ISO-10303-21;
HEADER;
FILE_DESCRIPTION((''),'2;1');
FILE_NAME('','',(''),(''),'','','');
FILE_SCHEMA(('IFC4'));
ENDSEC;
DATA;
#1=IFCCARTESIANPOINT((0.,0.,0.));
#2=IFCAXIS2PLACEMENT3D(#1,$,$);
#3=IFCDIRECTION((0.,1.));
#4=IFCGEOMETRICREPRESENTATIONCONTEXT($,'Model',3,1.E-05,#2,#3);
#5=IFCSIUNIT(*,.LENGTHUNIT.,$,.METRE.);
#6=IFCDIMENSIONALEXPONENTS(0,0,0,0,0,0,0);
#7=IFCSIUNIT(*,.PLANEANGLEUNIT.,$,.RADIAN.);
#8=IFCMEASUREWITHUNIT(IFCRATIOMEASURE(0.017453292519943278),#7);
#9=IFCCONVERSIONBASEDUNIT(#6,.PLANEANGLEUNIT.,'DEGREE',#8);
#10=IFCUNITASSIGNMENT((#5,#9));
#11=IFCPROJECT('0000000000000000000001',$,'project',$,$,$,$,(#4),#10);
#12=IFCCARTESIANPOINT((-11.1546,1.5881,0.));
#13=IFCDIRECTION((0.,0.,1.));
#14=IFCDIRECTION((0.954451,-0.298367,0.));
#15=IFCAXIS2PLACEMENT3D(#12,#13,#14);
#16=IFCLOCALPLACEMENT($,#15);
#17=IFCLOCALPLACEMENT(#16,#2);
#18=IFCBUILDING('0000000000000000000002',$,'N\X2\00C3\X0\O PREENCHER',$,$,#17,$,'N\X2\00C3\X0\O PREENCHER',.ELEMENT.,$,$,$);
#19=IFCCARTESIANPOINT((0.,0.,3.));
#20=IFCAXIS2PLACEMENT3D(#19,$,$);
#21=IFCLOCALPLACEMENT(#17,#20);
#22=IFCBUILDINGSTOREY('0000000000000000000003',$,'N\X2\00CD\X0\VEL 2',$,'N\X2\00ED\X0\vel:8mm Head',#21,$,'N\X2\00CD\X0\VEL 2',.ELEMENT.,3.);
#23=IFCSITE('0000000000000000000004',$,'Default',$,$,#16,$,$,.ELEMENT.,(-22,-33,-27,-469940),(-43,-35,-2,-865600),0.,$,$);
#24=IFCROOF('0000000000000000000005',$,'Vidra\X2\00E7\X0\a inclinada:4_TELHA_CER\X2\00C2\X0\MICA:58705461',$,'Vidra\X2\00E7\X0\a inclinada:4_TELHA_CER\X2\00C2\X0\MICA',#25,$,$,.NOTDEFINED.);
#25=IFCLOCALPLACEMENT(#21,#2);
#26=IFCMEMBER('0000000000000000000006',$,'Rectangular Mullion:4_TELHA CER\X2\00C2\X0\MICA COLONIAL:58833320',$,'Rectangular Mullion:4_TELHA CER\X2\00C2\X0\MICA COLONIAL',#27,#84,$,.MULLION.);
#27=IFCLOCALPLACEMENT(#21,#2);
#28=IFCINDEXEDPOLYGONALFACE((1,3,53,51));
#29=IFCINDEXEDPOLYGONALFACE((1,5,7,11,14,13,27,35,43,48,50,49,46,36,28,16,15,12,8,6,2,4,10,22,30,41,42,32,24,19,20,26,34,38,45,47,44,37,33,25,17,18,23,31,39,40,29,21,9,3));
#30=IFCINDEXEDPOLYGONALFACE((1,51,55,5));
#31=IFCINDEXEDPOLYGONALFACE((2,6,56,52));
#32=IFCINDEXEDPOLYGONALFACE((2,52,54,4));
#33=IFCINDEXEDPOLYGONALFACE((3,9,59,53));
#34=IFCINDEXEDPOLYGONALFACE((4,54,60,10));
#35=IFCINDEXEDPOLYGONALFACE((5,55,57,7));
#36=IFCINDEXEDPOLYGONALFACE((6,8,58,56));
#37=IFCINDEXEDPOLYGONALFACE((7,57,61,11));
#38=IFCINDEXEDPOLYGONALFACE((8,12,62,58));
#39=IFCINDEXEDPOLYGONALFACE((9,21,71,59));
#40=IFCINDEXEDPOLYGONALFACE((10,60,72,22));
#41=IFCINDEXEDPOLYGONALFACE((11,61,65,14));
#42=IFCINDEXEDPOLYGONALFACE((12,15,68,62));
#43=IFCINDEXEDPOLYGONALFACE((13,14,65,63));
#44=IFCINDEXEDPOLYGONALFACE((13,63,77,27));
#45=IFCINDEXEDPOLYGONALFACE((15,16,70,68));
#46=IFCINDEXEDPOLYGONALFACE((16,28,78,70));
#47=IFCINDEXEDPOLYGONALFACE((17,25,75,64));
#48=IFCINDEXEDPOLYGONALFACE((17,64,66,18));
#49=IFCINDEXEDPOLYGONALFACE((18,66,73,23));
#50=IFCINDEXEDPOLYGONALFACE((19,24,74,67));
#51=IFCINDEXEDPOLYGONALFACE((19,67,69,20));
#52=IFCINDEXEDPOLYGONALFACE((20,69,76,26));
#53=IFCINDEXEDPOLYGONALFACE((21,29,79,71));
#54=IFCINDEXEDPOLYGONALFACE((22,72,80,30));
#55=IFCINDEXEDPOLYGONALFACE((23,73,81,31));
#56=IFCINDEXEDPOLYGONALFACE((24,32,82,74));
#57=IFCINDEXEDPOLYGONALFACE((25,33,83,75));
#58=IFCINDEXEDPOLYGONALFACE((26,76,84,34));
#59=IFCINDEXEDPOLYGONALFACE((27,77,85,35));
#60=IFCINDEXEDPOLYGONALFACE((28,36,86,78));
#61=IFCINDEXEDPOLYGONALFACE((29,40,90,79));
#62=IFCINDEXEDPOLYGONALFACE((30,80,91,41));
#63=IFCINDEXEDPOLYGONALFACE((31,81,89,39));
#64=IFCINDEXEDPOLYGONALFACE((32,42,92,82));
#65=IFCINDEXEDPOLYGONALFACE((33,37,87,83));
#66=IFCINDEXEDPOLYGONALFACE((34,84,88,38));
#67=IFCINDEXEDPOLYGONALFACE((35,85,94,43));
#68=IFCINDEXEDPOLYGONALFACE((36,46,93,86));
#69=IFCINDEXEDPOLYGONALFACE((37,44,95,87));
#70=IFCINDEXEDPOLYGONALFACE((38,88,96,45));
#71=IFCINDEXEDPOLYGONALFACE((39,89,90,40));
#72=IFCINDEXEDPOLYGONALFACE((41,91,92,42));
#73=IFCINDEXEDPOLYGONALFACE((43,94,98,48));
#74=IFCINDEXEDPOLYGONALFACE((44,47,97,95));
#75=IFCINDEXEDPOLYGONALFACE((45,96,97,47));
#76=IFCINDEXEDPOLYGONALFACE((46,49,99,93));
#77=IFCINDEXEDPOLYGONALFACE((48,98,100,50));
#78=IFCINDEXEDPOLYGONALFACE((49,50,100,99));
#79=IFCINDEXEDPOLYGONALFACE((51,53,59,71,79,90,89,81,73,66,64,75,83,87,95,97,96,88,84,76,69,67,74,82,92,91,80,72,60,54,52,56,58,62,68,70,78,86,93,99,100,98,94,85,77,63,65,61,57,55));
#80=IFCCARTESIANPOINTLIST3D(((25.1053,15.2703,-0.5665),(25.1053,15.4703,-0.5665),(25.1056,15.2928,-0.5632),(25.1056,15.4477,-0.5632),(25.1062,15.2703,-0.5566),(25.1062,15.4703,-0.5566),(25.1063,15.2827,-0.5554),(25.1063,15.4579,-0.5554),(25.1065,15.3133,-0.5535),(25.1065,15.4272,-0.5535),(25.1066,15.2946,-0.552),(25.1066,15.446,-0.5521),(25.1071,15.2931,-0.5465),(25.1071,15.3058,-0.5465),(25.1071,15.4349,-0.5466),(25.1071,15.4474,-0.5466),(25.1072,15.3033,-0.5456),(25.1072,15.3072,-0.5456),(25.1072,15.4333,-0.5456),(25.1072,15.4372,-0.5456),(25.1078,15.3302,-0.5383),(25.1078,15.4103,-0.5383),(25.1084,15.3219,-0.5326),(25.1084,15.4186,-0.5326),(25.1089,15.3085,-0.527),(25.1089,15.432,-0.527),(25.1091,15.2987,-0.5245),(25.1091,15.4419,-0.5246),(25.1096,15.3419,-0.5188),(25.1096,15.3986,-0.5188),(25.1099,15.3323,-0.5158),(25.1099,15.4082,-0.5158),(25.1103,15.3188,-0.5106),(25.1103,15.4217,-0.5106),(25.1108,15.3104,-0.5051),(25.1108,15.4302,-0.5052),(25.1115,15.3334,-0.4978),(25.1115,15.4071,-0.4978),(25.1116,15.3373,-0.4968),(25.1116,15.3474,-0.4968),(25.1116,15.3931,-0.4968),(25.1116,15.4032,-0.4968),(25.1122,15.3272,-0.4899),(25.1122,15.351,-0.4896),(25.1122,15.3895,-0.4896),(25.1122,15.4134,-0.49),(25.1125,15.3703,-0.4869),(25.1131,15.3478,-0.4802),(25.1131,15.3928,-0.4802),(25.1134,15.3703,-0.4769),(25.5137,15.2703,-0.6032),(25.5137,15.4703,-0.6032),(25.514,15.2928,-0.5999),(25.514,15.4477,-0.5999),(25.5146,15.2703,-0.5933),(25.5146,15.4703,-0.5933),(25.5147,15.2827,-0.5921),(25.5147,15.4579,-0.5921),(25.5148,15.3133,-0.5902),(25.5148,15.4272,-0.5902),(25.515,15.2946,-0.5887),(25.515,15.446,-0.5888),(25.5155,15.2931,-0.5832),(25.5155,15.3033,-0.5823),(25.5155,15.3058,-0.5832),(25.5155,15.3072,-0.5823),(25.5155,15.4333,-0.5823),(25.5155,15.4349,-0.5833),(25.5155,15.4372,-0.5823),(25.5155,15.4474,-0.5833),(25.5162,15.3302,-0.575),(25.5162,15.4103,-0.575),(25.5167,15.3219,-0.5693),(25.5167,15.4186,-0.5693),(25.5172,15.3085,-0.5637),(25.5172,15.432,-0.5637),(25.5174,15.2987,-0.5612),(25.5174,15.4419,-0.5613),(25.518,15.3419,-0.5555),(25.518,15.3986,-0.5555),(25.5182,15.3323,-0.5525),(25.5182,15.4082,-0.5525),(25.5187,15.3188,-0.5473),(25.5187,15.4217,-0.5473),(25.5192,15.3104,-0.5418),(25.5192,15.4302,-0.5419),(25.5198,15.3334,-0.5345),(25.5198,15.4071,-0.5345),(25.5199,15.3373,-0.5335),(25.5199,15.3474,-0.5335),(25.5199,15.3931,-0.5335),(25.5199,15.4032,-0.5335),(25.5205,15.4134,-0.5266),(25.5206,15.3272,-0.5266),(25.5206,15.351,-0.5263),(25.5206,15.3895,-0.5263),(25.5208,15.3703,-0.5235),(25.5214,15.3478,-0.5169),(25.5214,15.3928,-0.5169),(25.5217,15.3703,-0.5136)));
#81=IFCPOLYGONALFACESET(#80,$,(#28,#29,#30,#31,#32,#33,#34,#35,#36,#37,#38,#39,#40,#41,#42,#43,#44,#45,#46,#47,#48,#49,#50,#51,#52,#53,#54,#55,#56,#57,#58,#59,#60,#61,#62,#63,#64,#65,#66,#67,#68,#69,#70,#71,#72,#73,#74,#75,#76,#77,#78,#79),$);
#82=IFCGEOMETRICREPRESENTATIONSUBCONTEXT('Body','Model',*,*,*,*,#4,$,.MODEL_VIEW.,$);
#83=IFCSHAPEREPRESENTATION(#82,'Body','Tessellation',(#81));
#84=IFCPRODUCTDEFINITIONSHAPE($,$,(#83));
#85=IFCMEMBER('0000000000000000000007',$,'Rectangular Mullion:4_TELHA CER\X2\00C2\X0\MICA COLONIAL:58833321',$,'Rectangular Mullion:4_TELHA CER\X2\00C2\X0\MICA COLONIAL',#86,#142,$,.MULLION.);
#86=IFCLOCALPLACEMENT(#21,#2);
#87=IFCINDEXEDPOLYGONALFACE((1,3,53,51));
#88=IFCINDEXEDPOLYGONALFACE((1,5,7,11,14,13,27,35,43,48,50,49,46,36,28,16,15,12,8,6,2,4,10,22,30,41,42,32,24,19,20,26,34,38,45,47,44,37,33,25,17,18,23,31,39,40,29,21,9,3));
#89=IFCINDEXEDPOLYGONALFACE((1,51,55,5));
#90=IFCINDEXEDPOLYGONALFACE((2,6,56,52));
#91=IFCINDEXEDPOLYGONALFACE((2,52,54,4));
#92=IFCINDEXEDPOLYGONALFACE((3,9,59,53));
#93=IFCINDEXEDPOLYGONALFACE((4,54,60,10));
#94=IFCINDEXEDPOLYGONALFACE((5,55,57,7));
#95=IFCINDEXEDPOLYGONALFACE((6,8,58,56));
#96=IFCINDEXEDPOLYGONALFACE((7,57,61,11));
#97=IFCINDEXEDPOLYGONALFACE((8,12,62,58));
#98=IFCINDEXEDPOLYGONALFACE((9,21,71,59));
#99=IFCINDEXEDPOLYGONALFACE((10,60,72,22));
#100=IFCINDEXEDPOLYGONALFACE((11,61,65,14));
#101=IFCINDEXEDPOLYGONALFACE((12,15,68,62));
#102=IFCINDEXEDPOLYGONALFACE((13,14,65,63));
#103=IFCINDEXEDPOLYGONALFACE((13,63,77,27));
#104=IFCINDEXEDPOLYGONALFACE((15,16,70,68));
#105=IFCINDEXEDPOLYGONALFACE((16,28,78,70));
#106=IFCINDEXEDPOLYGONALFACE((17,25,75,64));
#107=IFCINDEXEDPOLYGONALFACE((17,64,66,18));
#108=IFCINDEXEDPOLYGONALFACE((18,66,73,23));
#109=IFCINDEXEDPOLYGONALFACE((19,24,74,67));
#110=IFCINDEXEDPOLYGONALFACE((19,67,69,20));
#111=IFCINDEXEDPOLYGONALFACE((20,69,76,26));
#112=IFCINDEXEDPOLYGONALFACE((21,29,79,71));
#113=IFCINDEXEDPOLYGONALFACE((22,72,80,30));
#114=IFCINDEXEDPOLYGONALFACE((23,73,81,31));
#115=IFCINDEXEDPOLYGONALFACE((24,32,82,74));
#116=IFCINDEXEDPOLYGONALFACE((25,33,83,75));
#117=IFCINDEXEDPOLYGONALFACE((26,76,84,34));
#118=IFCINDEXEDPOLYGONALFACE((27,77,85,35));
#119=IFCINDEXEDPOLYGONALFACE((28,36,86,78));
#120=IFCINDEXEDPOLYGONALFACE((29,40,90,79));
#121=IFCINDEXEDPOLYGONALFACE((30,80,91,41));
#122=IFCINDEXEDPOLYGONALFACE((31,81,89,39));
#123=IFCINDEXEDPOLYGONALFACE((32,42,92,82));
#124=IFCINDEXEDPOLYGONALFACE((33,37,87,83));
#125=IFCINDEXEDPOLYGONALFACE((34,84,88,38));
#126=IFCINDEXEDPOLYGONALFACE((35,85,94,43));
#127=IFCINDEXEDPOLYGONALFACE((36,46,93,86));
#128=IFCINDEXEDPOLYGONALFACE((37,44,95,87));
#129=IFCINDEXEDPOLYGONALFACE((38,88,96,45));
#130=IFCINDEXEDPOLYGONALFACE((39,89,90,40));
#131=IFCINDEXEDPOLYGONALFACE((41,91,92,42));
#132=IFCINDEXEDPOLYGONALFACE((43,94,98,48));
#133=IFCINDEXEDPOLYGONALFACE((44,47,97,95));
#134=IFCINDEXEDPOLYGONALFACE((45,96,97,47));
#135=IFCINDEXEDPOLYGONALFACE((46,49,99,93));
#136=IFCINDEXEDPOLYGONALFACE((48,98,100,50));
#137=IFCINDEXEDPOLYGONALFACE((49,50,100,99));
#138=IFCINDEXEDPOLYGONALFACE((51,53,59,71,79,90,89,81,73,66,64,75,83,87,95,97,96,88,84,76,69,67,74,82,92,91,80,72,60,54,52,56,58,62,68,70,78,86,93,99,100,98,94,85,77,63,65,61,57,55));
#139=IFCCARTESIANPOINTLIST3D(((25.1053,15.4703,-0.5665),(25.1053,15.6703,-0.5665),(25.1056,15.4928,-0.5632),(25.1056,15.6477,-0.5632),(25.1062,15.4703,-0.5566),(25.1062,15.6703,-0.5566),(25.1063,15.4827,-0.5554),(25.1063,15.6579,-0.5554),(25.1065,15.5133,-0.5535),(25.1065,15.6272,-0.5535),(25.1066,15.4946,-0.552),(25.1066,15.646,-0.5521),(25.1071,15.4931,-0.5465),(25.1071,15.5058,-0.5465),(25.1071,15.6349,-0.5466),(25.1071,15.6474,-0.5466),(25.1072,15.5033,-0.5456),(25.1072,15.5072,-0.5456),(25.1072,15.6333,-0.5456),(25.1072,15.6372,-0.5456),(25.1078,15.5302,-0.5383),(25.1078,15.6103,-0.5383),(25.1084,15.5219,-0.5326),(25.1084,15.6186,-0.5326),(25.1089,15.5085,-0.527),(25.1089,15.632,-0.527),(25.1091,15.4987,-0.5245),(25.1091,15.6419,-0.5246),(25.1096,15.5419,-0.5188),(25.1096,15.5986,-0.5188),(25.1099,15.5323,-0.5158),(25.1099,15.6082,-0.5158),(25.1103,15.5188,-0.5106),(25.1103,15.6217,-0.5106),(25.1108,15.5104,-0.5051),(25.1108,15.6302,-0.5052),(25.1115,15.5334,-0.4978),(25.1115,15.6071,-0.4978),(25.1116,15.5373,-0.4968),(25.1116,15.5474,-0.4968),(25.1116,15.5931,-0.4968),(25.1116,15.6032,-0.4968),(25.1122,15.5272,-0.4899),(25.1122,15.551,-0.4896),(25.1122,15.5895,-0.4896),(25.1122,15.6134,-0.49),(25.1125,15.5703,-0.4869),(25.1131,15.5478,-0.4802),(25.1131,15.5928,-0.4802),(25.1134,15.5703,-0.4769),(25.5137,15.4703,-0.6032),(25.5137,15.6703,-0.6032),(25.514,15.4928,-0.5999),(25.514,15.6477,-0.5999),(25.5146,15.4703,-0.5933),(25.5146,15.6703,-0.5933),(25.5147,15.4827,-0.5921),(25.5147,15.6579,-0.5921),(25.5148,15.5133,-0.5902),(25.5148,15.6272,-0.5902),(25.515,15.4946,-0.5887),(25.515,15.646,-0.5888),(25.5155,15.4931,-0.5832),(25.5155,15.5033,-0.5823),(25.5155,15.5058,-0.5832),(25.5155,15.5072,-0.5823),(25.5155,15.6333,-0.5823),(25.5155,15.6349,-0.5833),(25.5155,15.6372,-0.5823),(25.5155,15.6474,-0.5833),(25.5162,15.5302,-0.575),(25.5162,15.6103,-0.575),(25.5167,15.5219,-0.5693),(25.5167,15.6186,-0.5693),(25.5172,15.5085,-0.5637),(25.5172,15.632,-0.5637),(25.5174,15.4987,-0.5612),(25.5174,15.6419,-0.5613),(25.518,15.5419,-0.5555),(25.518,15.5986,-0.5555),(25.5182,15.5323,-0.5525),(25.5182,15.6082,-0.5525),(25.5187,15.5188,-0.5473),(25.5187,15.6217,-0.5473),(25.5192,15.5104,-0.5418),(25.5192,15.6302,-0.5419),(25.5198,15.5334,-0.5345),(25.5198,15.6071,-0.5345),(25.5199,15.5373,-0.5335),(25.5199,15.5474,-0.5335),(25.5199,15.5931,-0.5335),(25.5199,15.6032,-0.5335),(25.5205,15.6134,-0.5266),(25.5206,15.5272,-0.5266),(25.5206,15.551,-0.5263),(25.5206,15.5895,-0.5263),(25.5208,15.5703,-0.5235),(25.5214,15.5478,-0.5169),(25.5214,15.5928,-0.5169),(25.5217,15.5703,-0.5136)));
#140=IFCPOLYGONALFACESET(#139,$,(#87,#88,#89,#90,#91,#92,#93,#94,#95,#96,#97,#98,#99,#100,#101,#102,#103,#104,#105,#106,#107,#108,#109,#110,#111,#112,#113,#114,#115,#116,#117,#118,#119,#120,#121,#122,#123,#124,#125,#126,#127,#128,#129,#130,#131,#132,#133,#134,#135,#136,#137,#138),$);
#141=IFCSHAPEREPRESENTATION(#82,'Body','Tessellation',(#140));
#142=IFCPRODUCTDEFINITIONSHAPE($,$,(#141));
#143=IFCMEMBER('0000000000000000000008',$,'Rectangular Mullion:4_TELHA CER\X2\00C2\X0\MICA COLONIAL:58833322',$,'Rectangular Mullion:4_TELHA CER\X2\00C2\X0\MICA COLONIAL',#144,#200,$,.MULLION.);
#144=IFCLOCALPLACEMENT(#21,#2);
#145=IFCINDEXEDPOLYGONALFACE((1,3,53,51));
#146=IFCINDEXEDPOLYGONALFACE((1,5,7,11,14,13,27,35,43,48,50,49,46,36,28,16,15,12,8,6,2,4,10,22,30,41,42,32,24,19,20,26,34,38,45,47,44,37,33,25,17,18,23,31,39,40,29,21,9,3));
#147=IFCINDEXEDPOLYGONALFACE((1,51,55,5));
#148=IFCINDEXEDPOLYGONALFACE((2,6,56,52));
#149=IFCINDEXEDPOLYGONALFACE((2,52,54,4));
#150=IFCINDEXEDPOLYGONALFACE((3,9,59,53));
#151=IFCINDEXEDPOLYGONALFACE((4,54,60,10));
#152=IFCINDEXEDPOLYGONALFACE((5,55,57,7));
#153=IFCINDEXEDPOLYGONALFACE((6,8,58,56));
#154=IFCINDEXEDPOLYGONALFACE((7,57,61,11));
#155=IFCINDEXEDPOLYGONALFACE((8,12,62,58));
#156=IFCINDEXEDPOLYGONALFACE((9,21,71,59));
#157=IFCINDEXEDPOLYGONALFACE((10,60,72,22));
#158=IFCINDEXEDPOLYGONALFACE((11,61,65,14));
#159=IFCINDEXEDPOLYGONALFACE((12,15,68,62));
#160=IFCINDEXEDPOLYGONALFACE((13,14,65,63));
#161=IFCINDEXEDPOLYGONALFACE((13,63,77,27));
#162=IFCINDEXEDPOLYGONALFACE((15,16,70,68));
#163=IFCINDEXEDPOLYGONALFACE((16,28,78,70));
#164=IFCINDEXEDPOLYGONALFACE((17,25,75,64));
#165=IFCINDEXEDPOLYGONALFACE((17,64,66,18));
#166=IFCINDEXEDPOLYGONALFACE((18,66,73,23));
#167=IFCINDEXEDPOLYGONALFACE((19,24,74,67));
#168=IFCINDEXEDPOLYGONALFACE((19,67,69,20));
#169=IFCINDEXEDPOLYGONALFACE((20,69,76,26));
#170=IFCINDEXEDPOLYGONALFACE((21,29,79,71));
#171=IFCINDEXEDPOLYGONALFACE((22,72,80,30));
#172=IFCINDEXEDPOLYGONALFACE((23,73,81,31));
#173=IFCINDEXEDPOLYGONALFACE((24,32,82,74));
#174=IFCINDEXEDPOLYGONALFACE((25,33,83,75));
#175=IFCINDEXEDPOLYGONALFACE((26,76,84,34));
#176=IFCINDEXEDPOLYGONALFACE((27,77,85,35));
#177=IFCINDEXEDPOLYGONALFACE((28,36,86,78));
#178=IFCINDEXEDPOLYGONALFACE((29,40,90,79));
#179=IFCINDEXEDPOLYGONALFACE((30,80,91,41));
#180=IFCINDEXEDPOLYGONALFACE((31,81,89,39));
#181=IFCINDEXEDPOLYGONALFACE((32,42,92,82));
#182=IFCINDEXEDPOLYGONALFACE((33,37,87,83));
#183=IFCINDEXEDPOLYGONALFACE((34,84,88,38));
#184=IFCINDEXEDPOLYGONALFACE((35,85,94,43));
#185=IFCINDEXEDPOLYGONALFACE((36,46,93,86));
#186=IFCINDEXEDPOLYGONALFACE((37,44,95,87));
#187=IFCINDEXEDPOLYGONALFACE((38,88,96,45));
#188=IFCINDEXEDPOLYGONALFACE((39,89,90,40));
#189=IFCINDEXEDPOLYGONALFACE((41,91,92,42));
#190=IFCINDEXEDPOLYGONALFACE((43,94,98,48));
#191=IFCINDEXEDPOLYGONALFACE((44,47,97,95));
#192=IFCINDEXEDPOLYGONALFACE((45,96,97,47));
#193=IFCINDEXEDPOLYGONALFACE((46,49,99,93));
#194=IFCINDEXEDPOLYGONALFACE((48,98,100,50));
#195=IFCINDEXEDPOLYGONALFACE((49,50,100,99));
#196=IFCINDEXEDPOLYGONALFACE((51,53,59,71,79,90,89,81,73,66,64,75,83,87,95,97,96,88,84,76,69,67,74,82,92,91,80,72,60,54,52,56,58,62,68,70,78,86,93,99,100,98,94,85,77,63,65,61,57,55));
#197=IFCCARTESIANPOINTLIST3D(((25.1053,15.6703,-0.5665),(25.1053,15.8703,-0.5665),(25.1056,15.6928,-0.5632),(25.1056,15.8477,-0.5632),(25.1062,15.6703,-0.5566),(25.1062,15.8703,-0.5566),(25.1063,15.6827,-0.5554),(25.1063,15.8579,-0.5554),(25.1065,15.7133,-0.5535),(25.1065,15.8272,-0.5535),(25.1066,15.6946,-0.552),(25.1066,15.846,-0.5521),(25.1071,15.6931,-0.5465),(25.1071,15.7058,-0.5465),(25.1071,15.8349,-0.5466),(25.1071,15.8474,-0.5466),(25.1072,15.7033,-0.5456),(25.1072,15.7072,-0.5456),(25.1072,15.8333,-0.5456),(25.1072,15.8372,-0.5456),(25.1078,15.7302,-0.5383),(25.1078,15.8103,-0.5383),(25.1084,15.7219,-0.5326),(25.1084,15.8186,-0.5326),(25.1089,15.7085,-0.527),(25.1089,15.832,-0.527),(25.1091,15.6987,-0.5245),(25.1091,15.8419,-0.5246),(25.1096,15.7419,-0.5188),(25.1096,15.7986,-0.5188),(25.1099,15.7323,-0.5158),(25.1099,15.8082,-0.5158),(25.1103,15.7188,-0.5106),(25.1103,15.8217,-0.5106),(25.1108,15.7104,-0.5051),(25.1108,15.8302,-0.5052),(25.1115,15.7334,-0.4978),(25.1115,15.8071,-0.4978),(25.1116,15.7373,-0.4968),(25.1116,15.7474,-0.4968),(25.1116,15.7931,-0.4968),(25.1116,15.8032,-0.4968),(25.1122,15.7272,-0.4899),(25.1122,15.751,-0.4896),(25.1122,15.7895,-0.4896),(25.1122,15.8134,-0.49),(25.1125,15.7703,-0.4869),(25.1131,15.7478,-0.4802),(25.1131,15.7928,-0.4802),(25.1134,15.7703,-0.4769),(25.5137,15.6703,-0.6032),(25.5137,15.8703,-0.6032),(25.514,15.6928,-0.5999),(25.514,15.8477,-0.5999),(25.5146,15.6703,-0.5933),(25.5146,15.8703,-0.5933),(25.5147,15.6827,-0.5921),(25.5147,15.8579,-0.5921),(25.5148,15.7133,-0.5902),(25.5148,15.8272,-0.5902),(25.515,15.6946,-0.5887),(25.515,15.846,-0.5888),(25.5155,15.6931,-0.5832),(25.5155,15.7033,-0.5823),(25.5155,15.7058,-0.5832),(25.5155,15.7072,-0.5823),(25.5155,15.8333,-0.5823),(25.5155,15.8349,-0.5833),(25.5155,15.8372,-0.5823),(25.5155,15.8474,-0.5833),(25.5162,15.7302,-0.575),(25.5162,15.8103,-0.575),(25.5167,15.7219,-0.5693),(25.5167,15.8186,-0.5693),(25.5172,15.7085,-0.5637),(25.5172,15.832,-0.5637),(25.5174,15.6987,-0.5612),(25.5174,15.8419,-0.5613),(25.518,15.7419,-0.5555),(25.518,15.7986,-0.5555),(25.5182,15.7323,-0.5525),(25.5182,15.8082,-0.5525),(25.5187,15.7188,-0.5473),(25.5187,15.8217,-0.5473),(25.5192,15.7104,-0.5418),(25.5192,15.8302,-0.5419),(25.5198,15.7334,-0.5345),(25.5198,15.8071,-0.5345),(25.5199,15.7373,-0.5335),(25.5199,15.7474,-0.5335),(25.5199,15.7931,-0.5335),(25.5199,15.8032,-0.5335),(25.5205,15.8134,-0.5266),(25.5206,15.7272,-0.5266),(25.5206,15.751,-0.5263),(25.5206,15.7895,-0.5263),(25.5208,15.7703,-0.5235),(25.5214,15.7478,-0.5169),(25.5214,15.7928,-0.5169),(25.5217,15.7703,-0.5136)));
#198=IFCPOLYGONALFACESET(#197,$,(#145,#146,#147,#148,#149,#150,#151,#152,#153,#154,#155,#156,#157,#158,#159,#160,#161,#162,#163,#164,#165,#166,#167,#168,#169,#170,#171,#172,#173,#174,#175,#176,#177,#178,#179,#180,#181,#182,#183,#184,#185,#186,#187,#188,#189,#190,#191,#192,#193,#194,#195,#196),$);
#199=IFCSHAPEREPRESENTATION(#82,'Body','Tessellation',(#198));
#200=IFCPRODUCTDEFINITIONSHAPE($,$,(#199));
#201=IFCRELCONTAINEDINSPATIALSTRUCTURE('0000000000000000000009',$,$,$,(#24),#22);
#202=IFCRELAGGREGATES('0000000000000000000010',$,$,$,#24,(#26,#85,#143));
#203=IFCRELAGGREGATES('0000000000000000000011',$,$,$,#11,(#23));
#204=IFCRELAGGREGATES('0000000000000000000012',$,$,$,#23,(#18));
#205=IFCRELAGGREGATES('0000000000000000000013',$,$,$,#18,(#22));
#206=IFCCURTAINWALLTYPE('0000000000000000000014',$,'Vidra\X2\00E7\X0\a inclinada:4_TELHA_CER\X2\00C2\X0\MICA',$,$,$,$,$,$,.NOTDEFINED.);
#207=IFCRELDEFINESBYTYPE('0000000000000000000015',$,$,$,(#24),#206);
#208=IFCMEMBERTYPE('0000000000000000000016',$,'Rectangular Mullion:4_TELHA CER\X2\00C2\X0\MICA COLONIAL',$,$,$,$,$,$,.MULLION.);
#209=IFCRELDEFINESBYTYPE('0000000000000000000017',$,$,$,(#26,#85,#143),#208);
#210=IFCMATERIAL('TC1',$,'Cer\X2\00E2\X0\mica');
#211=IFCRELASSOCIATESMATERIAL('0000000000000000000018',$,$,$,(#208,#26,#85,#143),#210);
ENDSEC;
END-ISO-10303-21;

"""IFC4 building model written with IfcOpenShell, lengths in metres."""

from ifc_helpers import new_model, entity, si_unit, converted_unit, direction, frame, origin, place, context, subcontext, project, spatial, line, arc, indexed_curve, outline, extrude, source, transform, mapped, material, type_object, type_shapes, element, aggregate, save


model = new_model("IFC4")

# Units and contexts
model_context = context("Model", 3, precision=1e-05, world=origin(), true_north=direction((0.0, 1.0)))
body_context = subcontext(model_context, "Body", "Model", "MODEL_VIEW")
ifc_project = project(units=[si_unit("LENGTHUNIT", "METRE"), converted_unit("PLANEANGLEUNIT", "DEGREE", entity("IfcRatioMeasure", 0.017453292519943278), si_unit("PLANEANGLEUNIT", "RADIAN"), dimensions=[0, 0, 0, 0, 0, 0, 0])], contexts=[model_context])

# Site, building, storey
site_placement = place(None, frame((-11.1546, 1.5881, 0.0), z_axis=(0.0, 0.0, 1.0), x_axis=(0.954451, -0.298367, 0.0)))
site = spatial("IfcSite", under=ifc_project, at=site_placement, Name="Default", CompositionType="ELEMENT", RefLatitude=(-22, -33, -27, -469940), RefLongitude=(-43, -35, -2, -865600), RefElevation=0.0)
building_placement = place(site_placement, origin())
building = spatial("IfcBuilding", under=site, at=building_placement, Name="NÃO PREENCHER", LongName="NÃO PREENCHER", CompositionType="ELEMENT")
storey_placement = place(building_placement, frame((0.0, 0.0, 3.0)))
storey = spatial("IfcBuildingStorey", under=building, at=storey_placement, Name="NÍVEL 2", ObjectType="Nível:8mm Head", LongName="NÍVEL 2", CompositionType="ELEMENT", Elevation=3.0)

# Roof, members
curtain_wall_type = type_object("IfcCurtainWallType", Name="Vidraça inclinada:4_TELHA_CERÂMICA", PredefinedType="NOTDEFINED")
roof_placement = place(storey_placement, frame((0.0, 0.0, -3.0)))
roof = element("IfcRoof", 1, at=roof_placement, inside=storey, type_object=curtain_wall_type, Name="Vidraça inclinada:4_TELHA_CERÂMICA:58705461", ObjectType="Vidraça inclinada:4_TELHA_CERÂMICA", PredefinedType="NOTDEFINED")
ifc_material = material(Name="TC1", Category="Cerâmica")
member_type = type_object("IfcMemberType", Name="Rectangular Mullion:4_TELHA CERÂMICA COLONIAL", PredefinedType="MULLION", material=ifc_material)
shared_shape = source(origin(), body_context, "Body", "SweptSolid", [
    extrude(outline(indexed_curve([(-0.029, -0.1), (-0.019, -0.1), (-0.0164, -0.0815), (-0.0089, -0.0645), (-0.0089, -0.0771), (0.061, 0.0), (-0.009, 0.0771), (-0.009, 0.0646), (-0.0165, 0.0816), (-0.019, 0.1), (-0.029, 0.1), (-0.0089, 0.0479), (0.041, 0.0229), (0.041, 0.0329), (0.0131, 0.0425), (-0.008, 0.0631), (-0.008, 0.067), (0.051, 0.0), (-0.008, -0.067), (-0.008, -0.0631), (0.0131, -0.0425), (0.041, -0.0329), (0.041, -0.0229), (-0.0089, -0.0479)], segments=[line(1, 2), arc(2, 3, 4), line(4, 5), arc(5, 6, 7), line(7, 8), arc(8, 9, 10), line(10, 11), arc(11, 12, 13), line(13, 14), arc(14, 15, 16), line(16, 17), arc(17, 18, 19), line(19, 20), arc(20, 21, 22), line(22, 23), arc(23, 24, 1)], self_intersect=False)), frame((0.0, -0.029, -0.41), z_axis=(0.0, 0.0, 1.0), x_axis=(0.0, -1.0, 0.0)), (0.0, 0.0, 1.0), 0.41),
])
type_shapes(member_type, [shared_shape])
member_1_placement = place(roof_placement, frame((25.1053, 15.3703, 2.4335), z_axis=(-0.99599, 0.0, 0.089469), x_axis=(0.0, 1.0, 0.0)))
member_1 = element("IfcMember", 2, at=member_1_placement, type_object=member_type, material=ifc_material, Name="Rectangular Mullion:4_TELHA CERÂMICA COLONIAL:58833320", ObjectType="Rectangular Mullion:4_TELHA CERÂMICA COLONIAL", PredefinedType="MULLION", context=body_context, shape_type="MappedRepresentation", body=[
    mapped(shared_shape, transform((0.0, 0.0, 0.0), scale=1.0)),
])
member_2_placement = place(roof_placement, frame((25.1053, 15.5703, 2.4335), z_axis=(-0.99599, 0.0, 0.089469), x_axis=(0.0, 1.0, 0.0)))
member_2 = element("IfcMember", 3, at=member_2_placement, type_object=member_type, material=ifc_material, Name="Rectangular Mullion:4_TELHA CERÂMICA COLONIAL:58833321", ObjectType="Rectangular Mullion:4_TELHA CERÂMICA COLONIAL", PredefinedType="MULLION", context=body_context, shape_type="MappedRepresentation", body=[
    mapped(shared_shape, transform((0.0, 0.0, 0.0), scale=1.0)),
])
member_3_placement = place(roof_placement, frame((25.1053, 15.7703, 2.4335), z_axis=(-0.99599, 0.0, 0.089469), x_axis=(0.0, 1.0, 0.0)))
member_3 = element("IfcMember", 4, at=member_3_placement, type_object=member_type, material=ifc_material, Name="Rectangular Mullion:4_TELHA CERÂMICA COLONIAL:58833322", ObjectType="Rectangular Mullion:4_TELHA CERÂMICA COLONIAL", PredefinedType="MULLION", context=body_context, shape_type="MappedRepresentation", body=[
    mapped(shared_shape, transform((0.0, 0.0, 0.0), scale=1.0)),
])
aggregate(roof, [member_1, member_2, member_3])

save(model, "model.ifc")
